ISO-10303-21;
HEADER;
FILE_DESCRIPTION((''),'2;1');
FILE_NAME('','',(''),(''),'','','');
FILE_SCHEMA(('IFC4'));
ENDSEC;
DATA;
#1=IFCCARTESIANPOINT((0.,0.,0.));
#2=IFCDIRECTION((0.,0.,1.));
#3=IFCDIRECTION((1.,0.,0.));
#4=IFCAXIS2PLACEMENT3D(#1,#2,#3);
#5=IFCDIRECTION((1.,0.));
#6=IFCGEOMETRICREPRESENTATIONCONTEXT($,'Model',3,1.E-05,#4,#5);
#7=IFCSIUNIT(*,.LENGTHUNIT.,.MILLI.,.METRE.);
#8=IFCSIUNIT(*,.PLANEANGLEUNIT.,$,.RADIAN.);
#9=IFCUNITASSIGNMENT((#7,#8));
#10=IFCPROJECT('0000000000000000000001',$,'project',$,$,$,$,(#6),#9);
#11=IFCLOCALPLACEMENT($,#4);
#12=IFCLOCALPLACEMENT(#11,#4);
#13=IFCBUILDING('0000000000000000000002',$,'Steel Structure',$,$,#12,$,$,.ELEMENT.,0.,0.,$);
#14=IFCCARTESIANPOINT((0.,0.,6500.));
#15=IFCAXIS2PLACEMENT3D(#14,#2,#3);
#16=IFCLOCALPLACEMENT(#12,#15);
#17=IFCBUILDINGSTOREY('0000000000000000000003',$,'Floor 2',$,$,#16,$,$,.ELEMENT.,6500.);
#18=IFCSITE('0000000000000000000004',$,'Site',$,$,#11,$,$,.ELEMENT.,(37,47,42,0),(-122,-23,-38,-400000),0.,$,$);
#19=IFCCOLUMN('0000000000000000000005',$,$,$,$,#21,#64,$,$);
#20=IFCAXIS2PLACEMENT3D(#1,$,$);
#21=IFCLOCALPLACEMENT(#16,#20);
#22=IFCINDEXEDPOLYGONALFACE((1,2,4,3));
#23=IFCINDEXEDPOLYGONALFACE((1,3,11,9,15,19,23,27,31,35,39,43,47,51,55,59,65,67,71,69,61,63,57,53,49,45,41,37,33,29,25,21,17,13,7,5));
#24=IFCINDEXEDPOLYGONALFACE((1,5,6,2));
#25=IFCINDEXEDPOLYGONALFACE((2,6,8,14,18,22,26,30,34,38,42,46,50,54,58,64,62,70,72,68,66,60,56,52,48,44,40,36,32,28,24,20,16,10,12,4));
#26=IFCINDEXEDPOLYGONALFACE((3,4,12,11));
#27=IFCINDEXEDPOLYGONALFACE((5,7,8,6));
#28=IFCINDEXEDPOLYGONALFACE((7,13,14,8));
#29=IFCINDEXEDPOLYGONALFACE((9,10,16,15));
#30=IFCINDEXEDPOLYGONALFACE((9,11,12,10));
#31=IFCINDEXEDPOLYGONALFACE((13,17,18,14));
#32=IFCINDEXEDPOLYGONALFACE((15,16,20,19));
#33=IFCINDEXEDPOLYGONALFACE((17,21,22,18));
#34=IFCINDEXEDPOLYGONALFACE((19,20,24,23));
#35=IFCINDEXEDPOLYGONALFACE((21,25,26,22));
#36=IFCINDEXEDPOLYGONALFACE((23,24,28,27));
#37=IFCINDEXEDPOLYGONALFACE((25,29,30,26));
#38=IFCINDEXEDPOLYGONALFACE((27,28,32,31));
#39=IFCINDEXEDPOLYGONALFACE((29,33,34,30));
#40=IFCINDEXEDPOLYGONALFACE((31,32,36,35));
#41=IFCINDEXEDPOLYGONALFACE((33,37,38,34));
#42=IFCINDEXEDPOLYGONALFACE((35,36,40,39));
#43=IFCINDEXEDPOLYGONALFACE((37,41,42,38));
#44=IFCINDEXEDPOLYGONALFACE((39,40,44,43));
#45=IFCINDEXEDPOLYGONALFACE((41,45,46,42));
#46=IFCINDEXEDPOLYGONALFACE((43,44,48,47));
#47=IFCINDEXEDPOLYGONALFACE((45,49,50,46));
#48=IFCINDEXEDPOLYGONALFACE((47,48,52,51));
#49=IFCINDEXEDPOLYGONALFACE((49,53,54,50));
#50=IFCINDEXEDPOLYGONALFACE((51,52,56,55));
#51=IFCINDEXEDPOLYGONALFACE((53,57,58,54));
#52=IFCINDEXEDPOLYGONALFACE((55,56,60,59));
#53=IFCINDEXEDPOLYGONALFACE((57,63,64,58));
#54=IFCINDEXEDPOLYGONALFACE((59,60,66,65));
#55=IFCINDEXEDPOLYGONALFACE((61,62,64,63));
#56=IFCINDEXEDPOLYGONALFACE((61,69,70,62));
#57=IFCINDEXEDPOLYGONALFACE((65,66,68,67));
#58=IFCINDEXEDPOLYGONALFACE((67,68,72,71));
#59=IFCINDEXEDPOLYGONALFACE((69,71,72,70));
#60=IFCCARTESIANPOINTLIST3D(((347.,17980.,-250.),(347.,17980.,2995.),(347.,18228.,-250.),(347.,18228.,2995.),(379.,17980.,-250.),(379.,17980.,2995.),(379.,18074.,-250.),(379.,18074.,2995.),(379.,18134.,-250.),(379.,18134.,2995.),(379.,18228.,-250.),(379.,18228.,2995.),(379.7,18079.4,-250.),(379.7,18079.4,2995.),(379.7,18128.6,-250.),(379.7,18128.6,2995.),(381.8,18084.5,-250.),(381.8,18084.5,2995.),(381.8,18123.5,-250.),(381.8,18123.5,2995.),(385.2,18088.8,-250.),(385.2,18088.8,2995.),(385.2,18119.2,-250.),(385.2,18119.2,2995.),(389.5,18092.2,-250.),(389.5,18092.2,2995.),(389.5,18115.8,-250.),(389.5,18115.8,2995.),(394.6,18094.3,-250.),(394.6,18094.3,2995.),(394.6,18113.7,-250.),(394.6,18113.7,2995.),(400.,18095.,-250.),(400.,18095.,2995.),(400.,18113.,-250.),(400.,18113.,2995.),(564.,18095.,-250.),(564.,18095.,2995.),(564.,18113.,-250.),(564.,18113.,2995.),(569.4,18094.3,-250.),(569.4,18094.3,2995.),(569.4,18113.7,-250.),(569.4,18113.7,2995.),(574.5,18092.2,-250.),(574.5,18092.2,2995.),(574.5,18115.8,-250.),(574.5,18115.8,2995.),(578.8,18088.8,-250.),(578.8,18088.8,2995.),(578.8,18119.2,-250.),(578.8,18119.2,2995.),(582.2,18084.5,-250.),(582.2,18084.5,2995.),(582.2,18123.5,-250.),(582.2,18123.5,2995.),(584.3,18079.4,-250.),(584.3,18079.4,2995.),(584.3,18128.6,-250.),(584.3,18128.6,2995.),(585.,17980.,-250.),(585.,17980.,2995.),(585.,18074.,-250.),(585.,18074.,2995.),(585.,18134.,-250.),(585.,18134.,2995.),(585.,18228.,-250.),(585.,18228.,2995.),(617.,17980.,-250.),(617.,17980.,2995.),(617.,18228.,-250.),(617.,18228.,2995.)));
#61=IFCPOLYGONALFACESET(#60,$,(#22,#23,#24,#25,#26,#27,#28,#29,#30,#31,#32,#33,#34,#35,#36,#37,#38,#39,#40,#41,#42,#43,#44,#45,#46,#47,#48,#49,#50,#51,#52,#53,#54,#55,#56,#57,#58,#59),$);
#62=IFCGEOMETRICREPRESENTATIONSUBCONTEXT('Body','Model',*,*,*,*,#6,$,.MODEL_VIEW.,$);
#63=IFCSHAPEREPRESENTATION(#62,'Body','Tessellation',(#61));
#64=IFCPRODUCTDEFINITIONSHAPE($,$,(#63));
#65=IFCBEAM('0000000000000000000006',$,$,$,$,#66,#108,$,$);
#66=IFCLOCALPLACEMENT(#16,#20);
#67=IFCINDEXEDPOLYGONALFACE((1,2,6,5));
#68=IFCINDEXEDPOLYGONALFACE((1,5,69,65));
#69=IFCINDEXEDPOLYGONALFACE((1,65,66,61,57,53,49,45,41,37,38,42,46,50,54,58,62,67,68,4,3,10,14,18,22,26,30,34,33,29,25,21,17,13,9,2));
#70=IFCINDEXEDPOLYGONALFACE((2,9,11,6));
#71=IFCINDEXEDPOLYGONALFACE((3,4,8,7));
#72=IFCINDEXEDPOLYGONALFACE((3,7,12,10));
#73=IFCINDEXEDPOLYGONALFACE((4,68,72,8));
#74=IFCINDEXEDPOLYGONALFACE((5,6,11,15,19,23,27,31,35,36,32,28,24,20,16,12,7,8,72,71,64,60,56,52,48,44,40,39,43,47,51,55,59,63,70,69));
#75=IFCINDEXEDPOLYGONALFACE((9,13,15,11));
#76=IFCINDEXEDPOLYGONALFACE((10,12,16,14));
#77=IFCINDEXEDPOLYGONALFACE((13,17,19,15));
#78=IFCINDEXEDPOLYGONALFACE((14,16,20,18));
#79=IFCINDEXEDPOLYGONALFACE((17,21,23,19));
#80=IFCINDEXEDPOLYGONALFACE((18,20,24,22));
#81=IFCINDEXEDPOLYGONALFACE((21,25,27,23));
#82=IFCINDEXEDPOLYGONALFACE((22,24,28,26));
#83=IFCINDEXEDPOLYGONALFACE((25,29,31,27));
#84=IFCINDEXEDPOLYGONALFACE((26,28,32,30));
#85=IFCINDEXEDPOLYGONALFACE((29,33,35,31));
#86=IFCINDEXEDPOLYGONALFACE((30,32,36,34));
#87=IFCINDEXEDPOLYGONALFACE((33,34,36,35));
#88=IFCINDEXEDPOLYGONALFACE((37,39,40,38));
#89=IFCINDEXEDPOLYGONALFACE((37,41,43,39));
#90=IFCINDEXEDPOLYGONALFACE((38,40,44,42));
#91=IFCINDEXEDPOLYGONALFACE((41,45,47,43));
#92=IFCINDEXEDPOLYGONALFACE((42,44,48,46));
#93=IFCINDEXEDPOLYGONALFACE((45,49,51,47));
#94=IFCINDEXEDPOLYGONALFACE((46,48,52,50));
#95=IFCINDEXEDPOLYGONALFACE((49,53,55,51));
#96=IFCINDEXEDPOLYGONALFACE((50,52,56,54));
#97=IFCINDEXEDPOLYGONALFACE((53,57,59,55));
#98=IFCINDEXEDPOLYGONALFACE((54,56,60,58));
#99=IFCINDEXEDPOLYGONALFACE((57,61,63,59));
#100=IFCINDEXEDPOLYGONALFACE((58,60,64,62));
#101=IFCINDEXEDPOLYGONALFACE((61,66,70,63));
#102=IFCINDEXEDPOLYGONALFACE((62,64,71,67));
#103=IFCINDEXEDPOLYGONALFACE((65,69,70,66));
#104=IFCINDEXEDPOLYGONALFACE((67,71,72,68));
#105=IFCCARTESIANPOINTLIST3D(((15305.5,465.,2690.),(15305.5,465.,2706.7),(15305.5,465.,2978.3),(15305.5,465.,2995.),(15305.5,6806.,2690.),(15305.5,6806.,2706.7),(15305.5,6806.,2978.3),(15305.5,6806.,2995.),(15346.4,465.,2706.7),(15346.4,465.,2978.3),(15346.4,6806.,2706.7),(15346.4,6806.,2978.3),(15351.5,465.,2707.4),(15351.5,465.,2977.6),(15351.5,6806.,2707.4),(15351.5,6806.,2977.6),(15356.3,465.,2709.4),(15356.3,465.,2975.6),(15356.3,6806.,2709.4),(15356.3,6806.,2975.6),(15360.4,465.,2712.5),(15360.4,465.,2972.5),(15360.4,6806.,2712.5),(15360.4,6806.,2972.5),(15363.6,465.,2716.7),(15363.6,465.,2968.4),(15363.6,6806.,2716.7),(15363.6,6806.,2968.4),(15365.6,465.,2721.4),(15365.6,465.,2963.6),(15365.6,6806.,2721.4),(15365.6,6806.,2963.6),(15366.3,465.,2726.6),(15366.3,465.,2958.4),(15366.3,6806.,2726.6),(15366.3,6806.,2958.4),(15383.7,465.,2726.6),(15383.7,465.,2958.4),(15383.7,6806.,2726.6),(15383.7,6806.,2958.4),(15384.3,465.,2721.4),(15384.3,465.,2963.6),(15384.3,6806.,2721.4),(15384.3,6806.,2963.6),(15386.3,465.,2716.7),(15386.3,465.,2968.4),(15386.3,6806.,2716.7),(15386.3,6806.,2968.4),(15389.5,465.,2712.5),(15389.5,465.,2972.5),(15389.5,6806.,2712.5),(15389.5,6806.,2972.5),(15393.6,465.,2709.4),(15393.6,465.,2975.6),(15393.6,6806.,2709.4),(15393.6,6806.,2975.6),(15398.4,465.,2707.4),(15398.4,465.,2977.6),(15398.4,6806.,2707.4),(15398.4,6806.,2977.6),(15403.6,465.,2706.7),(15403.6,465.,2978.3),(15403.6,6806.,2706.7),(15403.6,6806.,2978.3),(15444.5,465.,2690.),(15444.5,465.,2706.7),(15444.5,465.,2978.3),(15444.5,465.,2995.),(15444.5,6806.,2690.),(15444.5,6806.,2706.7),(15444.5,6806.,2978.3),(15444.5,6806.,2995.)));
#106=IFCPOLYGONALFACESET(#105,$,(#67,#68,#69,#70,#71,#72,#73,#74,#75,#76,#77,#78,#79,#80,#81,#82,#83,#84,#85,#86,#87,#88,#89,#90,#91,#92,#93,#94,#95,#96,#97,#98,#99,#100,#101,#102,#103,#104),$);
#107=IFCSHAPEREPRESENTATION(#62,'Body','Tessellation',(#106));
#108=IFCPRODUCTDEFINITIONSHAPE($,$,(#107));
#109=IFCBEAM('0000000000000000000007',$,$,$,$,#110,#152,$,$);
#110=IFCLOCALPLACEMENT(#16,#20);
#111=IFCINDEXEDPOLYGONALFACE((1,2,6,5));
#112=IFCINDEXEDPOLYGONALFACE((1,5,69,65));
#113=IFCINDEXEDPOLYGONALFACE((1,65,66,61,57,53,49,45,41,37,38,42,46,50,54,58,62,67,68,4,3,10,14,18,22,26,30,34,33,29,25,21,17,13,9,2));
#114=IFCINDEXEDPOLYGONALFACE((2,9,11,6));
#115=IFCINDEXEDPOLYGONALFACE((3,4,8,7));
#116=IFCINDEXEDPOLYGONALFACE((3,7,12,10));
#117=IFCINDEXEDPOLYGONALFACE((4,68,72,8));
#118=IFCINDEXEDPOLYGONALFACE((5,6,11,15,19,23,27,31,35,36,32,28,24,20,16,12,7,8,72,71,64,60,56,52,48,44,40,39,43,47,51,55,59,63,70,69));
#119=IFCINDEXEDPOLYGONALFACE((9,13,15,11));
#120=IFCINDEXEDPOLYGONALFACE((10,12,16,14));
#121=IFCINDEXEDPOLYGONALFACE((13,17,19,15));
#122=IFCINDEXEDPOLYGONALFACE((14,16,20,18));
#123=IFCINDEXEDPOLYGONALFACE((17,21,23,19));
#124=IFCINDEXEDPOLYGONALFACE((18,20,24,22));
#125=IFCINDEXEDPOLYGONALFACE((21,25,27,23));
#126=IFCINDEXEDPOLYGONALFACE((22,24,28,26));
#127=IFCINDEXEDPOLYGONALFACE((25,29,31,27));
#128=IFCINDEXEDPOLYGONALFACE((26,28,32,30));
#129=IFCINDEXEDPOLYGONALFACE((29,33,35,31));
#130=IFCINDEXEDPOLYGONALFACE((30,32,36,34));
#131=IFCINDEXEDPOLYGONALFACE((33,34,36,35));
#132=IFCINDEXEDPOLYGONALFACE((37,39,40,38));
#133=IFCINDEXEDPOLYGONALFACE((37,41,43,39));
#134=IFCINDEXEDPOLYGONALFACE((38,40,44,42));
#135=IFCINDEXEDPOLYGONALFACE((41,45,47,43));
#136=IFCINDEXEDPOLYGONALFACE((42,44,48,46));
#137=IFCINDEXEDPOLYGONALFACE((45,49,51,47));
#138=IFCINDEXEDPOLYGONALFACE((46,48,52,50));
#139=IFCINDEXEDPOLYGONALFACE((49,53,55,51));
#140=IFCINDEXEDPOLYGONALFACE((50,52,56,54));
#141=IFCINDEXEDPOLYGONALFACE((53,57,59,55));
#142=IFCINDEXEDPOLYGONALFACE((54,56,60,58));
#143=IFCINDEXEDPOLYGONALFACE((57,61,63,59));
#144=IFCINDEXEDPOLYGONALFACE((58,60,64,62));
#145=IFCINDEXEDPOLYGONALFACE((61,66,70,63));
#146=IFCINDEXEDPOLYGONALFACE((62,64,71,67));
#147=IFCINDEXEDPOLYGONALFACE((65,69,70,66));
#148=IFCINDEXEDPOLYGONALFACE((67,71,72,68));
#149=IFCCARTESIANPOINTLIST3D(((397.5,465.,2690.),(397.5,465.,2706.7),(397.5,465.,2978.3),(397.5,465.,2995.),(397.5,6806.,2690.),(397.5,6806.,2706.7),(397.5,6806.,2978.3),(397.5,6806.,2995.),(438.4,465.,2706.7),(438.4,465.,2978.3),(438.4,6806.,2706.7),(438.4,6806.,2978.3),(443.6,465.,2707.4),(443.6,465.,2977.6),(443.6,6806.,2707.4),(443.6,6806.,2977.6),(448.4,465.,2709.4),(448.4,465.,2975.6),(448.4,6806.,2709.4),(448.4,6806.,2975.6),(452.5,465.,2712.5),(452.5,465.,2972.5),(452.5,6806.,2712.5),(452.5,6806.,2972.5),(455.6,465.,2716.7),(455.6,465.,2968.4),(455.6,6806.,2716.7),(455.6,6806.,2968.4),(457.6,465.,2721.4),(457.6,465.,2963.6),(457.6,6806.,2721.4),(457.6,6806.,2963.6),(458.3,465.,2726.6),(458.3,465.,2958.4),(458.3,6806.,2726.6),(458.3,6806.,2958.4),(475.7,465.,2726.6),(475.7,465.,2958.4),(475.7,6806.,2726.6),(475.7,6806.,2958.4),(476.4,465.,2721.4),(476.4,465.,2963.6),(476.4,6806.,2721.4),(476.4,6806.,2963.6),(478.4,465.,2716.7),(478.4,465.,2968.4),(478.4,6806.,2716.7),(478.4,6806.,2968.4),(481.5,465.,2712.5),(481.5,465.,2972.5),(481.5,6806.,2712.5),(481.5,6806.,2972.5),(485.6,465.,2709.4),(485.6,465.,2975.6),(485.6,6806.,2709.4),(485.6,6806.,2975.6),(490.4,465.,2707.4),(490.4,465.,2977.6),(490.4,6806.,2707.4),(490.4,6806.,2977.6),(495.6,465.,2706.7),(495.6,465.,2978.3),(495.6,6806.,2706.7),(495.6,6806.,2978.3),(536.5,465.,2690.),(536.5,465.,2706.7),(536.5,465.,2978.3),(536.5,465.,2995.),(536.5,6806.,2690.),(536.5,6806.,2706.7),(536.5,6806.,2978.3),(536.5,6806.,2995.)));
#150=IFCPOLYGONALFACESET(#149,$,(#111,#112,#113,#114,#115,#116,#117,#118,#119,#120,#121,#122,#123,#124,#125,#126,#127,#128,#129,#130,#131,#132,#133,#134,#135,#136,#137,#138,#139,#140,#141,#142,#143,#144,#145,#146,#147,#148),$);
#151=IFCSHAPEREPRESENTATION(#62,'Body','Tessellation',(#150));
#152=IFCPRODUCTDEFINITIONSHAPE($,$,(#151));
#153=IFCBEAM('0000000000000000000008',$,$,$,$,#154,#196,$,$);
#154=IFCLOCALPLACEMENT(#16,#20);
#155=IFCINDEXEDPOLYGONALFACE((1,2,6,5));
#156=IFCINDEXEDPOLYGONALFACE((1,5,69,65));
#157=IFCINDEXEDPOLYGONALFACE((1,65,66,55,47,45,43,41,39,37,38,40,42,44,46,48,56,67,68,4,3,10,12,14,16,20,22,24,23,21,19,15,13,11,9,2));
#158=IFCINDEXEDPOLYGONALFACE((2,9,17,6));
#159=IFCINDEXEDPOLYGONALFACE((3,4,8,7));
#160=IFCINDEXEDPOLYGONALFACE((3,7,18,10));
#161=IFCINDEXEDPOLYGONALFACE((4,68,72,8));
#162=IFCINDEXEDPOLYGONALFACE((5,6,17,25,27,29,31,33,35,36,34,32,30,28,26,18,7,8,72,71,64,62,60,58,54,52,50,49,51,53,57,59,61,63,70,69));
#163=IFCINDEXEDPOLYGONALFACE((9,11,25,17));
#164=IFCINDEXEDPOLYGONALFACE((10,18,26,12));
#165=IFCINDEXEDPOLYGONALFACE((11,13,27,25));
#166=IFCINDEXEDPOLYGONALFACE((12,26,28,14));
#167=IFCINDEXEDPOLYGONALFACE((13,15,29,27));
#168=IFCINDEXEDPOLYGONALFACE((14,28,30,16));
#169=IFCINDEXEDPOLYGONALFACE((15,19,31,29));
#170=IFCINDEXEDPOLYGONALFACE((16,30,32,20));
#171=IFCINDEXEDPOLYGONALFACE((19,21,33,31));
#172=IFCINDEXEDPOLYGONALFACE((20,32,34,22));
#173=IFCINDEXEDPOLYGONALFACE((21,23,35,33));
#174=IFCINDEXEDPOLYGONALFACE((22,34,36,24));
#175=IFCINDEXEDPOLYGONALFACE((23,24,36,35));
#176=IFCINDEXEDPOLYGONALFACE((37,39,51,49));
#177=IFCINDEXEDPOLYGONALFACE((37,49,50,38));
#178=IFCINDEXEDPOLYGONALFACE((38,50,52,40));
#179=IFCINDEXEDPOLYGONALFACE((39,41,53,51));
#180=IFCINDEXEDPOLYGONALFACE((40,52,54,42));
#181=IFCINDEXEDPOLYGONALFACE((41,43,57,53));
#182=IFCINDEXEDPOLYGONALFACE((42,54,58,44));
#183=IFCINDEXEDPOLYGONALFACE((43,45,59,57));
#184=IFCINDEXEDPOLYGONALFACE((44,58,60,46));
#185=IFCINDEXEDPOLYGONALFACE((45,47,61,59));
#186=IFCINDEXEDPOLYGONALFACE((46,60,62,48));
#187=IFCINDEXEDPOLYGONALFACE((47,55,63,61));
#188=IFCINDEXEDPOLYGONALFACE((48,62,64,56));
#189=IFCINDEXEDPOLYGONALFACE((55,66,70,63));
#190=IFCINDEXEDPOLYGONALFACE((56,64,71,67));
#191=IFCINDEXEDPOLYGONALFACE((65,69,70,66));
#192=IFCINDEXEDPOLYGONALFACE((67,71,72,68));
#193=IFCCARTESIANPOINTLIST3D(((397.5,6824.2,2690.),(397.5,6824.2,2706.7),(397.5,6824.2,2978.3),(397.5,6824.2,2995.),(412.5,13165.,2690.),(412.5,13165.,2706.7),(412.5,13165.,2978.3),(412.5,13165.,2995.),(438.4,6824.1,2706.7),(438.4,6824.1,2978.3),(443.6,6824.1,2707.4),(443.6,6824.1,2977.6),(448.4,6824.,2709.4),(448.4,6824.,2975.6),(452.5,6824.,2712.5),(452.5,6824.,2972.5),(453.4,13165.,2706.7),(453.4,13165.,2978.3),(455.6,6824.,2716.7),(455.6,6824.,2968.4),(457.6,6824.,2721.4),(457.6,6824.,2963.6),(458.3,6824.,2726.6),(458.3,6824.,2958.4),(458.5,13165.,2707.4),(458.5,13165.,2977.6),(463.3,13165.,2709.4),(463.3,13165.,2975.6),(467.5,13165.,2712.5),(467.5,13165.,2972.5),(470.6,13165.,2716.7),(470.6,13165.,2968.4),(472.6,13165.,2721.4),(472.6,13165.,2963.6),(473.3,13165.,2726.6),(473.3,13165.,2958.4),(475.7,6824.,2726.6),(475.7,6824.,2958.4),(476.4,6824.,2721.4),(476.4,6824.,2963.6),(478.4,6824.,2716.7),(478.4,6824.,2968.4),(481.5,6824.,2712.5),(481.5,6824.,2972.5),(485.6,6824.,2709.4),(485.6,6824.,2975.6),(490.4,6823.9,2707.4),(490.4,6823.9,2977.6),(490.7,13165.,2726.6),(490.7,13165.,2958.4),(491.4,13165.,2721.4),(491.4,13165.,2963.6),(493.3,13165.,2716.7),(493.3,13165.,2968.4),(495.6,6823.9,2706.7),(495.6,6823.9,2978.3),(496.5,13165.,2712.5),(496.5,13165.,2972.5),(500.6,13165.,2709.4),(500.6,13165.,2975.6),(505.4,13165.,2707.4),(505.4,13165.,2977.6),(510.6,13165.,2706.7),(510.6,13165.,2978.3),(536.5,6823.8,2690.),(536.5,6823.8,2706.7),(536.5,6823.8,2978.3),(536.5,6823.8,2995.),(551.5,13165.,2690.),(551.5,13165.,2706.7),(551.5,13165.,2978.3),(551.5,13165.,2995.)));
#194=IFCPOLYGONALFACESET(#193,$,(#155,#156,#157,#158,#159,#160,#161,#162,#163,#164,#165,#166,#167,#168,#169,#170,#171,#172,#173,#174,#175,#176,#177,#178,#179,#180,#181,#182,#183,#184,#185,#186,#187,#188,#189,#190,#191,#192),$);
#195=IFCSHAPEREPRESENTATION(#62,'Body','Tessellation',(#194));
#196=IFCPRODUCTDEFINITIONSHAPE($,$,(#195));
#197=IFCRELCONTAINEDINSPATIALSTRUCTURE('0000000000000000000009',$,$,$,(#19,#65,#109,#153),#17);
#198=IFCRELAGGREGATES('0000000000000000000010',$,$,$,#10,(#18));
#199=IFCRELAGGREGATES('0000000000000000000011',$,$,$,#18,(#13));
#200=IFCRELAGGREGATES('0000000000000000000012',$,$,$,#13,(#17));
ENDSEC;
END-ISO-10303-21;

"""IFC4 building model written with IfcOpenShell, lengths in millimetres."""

from ifc_helpers import new_model, si_unit, direction, frame, origin_with_axes, origin_2d_with_axis, place, context, subcontext, project, spatial, polyline, i_section, extrude, clip, bounded_halfspace, element, save


model = new_model("IFC4")

# Units and contexts
model_context = context("Model", 3, precision=1e-05, world=origin_with_axes(), true_north=direction((1.0, 0.0)))
body_context = subcontext(model_context, "Body", "Model", "MODEL_VIEW")
ifc_project = project(units=[si_unit("LENGTHUNIT", "METRE", prefix="MILLI"), si_unit("PLANEANGLEUNIT", "RADIAN")], contexts=[model_context])

# Site, building, storey
site_placement = place(None, origin_with_axes())
site = spatial("IfcSite", under=ifc_project, at=site_placement, Name="Site", CompositionType="ELEMENT", RefLatitude=(37, 47, 42, 0), RefLongitude=(-122, -23, -38, -400000), RefElevation=0.0)
building_placement = place(site_placement, origin_with_axes())
building = spatial("IfcBuilding", under=site, at=building_placement, Name="Steel Structure", CompositionType="ELEMENT", ElevationOfRefHeight=0.0, ElevationOfTerrain=0.0)
storey_placement = place(building_placement, frame((0.0, 0.0, 6500.0), z_axis=(0.0, 0.0, 1.0), x_axis=(1.0, 0.0, 0.0)))
storey = spatial("IfcBuildingStorey", under=building, at=storey_placement, Name="Floor 2", CompositionType="ELEMENT", Elevation=6500.0)

# Column
for number, where, z_axis, x_axis in (
    (1, (482.0, 18104.0, -250.0), (0.0, 0.0, 1.0), (0.0, -1.0, 0.0)),
):
    element("IfcColumn", number, at=place(storey_placement, frame(where, z_axis=z_axis, x_axis=x_axis)), inside=storey, context=body_context, shape_type="SweptSolid", body=[
        extrude(i_section(OverallWidth=248.0, OverallDepth=270.0, WebThickness=18.0, FlangeThickness=32.0, FilletRadius=21.0, at=origin_2d_with_axis()), origin_with_axes(), (0.0, 0.0, 1.0), 3245.0),
    ])

# Beams
for number, where, z_axis, x_axis in (
    (2, (15375.0, 465.0, 2842.5), (0.0, 1.0, 0.0), (-1.0, 0.0, 0.0)),
    (3, (467.0, 465.0, 2842.5), (0.0, 1.0, 0.0), (-1.0, 0.0, 0.0)),
):
    element("IfcBeam", number, at=place(storey_placement, frame(where, z_axis=z_axis, x_axis=x_axis)), inside=storey, context=body_context, shape_type="SweptSolid", body=[
        extrude(i_section(OverallWidth=139.0, OverallDepth=305.0, WebThickness=17.4, FlangeThickness=16.7, FilletRadius=19.9, at=origin_2d_with_axis()), origin_with_axes(), (0.0, 0.0, 1.0), 6341.0),
    ])
beam_1_placement = place(storey_placement, frame((482.0, 13165.2, 2690.0), z_axis=(-0.002362, -0.999997, 0.0), x_axis=(0.999997, -0.002362, 0.0)))
element("IfcBeam", 4, at=beam_1_placement, inside=storey, context=body_context, shape_type="Clipping", body=[
    clip(extrude(i_section(OverallWidth=139.0, OverallDepth=305.0, WebThickness=17.4, FlangeThickness=16.7, FilletRadius=19.9, at=origin_2d_with_axis()), frame((0.0, 152.5, 0.0), z_axis=(0.0, 0.0, 1.0), x_axis=(1.0, 0.0, 0.0)), (0.0, 0.0, 1.0), 6341.2), bounded_halfspace(frame((-482.0, -9190.0, 1.3), z_axis=(-0.002362, 0.0, -0.999997), x_axis=(-0.999997, 0.0, 0.002362)), False, frame((0.0, 152.5, 0.0), z_axis=(0.0, 0.0, 1.0), x_axis=(1.0, 0.0, 0.0)), polyline([(69.5, 152.5), (69.5, 135.8), (28.6, 135.8), (8.7, 115.9), (8.7, -115.9), (28.6, -135.8), (69.5, -135.8), (69.5, -152.5), (-69.5, -152.5), (-69.5, -135.8), (-28.6, -135.8), (-8.7, -115.9), (-8.7, 115.9), (-28.6, 135.8), (-69.5, 135.8), (-69.5, 152.5), (69.5, 152.5)]))),
])

save(model, "model.ifc")
